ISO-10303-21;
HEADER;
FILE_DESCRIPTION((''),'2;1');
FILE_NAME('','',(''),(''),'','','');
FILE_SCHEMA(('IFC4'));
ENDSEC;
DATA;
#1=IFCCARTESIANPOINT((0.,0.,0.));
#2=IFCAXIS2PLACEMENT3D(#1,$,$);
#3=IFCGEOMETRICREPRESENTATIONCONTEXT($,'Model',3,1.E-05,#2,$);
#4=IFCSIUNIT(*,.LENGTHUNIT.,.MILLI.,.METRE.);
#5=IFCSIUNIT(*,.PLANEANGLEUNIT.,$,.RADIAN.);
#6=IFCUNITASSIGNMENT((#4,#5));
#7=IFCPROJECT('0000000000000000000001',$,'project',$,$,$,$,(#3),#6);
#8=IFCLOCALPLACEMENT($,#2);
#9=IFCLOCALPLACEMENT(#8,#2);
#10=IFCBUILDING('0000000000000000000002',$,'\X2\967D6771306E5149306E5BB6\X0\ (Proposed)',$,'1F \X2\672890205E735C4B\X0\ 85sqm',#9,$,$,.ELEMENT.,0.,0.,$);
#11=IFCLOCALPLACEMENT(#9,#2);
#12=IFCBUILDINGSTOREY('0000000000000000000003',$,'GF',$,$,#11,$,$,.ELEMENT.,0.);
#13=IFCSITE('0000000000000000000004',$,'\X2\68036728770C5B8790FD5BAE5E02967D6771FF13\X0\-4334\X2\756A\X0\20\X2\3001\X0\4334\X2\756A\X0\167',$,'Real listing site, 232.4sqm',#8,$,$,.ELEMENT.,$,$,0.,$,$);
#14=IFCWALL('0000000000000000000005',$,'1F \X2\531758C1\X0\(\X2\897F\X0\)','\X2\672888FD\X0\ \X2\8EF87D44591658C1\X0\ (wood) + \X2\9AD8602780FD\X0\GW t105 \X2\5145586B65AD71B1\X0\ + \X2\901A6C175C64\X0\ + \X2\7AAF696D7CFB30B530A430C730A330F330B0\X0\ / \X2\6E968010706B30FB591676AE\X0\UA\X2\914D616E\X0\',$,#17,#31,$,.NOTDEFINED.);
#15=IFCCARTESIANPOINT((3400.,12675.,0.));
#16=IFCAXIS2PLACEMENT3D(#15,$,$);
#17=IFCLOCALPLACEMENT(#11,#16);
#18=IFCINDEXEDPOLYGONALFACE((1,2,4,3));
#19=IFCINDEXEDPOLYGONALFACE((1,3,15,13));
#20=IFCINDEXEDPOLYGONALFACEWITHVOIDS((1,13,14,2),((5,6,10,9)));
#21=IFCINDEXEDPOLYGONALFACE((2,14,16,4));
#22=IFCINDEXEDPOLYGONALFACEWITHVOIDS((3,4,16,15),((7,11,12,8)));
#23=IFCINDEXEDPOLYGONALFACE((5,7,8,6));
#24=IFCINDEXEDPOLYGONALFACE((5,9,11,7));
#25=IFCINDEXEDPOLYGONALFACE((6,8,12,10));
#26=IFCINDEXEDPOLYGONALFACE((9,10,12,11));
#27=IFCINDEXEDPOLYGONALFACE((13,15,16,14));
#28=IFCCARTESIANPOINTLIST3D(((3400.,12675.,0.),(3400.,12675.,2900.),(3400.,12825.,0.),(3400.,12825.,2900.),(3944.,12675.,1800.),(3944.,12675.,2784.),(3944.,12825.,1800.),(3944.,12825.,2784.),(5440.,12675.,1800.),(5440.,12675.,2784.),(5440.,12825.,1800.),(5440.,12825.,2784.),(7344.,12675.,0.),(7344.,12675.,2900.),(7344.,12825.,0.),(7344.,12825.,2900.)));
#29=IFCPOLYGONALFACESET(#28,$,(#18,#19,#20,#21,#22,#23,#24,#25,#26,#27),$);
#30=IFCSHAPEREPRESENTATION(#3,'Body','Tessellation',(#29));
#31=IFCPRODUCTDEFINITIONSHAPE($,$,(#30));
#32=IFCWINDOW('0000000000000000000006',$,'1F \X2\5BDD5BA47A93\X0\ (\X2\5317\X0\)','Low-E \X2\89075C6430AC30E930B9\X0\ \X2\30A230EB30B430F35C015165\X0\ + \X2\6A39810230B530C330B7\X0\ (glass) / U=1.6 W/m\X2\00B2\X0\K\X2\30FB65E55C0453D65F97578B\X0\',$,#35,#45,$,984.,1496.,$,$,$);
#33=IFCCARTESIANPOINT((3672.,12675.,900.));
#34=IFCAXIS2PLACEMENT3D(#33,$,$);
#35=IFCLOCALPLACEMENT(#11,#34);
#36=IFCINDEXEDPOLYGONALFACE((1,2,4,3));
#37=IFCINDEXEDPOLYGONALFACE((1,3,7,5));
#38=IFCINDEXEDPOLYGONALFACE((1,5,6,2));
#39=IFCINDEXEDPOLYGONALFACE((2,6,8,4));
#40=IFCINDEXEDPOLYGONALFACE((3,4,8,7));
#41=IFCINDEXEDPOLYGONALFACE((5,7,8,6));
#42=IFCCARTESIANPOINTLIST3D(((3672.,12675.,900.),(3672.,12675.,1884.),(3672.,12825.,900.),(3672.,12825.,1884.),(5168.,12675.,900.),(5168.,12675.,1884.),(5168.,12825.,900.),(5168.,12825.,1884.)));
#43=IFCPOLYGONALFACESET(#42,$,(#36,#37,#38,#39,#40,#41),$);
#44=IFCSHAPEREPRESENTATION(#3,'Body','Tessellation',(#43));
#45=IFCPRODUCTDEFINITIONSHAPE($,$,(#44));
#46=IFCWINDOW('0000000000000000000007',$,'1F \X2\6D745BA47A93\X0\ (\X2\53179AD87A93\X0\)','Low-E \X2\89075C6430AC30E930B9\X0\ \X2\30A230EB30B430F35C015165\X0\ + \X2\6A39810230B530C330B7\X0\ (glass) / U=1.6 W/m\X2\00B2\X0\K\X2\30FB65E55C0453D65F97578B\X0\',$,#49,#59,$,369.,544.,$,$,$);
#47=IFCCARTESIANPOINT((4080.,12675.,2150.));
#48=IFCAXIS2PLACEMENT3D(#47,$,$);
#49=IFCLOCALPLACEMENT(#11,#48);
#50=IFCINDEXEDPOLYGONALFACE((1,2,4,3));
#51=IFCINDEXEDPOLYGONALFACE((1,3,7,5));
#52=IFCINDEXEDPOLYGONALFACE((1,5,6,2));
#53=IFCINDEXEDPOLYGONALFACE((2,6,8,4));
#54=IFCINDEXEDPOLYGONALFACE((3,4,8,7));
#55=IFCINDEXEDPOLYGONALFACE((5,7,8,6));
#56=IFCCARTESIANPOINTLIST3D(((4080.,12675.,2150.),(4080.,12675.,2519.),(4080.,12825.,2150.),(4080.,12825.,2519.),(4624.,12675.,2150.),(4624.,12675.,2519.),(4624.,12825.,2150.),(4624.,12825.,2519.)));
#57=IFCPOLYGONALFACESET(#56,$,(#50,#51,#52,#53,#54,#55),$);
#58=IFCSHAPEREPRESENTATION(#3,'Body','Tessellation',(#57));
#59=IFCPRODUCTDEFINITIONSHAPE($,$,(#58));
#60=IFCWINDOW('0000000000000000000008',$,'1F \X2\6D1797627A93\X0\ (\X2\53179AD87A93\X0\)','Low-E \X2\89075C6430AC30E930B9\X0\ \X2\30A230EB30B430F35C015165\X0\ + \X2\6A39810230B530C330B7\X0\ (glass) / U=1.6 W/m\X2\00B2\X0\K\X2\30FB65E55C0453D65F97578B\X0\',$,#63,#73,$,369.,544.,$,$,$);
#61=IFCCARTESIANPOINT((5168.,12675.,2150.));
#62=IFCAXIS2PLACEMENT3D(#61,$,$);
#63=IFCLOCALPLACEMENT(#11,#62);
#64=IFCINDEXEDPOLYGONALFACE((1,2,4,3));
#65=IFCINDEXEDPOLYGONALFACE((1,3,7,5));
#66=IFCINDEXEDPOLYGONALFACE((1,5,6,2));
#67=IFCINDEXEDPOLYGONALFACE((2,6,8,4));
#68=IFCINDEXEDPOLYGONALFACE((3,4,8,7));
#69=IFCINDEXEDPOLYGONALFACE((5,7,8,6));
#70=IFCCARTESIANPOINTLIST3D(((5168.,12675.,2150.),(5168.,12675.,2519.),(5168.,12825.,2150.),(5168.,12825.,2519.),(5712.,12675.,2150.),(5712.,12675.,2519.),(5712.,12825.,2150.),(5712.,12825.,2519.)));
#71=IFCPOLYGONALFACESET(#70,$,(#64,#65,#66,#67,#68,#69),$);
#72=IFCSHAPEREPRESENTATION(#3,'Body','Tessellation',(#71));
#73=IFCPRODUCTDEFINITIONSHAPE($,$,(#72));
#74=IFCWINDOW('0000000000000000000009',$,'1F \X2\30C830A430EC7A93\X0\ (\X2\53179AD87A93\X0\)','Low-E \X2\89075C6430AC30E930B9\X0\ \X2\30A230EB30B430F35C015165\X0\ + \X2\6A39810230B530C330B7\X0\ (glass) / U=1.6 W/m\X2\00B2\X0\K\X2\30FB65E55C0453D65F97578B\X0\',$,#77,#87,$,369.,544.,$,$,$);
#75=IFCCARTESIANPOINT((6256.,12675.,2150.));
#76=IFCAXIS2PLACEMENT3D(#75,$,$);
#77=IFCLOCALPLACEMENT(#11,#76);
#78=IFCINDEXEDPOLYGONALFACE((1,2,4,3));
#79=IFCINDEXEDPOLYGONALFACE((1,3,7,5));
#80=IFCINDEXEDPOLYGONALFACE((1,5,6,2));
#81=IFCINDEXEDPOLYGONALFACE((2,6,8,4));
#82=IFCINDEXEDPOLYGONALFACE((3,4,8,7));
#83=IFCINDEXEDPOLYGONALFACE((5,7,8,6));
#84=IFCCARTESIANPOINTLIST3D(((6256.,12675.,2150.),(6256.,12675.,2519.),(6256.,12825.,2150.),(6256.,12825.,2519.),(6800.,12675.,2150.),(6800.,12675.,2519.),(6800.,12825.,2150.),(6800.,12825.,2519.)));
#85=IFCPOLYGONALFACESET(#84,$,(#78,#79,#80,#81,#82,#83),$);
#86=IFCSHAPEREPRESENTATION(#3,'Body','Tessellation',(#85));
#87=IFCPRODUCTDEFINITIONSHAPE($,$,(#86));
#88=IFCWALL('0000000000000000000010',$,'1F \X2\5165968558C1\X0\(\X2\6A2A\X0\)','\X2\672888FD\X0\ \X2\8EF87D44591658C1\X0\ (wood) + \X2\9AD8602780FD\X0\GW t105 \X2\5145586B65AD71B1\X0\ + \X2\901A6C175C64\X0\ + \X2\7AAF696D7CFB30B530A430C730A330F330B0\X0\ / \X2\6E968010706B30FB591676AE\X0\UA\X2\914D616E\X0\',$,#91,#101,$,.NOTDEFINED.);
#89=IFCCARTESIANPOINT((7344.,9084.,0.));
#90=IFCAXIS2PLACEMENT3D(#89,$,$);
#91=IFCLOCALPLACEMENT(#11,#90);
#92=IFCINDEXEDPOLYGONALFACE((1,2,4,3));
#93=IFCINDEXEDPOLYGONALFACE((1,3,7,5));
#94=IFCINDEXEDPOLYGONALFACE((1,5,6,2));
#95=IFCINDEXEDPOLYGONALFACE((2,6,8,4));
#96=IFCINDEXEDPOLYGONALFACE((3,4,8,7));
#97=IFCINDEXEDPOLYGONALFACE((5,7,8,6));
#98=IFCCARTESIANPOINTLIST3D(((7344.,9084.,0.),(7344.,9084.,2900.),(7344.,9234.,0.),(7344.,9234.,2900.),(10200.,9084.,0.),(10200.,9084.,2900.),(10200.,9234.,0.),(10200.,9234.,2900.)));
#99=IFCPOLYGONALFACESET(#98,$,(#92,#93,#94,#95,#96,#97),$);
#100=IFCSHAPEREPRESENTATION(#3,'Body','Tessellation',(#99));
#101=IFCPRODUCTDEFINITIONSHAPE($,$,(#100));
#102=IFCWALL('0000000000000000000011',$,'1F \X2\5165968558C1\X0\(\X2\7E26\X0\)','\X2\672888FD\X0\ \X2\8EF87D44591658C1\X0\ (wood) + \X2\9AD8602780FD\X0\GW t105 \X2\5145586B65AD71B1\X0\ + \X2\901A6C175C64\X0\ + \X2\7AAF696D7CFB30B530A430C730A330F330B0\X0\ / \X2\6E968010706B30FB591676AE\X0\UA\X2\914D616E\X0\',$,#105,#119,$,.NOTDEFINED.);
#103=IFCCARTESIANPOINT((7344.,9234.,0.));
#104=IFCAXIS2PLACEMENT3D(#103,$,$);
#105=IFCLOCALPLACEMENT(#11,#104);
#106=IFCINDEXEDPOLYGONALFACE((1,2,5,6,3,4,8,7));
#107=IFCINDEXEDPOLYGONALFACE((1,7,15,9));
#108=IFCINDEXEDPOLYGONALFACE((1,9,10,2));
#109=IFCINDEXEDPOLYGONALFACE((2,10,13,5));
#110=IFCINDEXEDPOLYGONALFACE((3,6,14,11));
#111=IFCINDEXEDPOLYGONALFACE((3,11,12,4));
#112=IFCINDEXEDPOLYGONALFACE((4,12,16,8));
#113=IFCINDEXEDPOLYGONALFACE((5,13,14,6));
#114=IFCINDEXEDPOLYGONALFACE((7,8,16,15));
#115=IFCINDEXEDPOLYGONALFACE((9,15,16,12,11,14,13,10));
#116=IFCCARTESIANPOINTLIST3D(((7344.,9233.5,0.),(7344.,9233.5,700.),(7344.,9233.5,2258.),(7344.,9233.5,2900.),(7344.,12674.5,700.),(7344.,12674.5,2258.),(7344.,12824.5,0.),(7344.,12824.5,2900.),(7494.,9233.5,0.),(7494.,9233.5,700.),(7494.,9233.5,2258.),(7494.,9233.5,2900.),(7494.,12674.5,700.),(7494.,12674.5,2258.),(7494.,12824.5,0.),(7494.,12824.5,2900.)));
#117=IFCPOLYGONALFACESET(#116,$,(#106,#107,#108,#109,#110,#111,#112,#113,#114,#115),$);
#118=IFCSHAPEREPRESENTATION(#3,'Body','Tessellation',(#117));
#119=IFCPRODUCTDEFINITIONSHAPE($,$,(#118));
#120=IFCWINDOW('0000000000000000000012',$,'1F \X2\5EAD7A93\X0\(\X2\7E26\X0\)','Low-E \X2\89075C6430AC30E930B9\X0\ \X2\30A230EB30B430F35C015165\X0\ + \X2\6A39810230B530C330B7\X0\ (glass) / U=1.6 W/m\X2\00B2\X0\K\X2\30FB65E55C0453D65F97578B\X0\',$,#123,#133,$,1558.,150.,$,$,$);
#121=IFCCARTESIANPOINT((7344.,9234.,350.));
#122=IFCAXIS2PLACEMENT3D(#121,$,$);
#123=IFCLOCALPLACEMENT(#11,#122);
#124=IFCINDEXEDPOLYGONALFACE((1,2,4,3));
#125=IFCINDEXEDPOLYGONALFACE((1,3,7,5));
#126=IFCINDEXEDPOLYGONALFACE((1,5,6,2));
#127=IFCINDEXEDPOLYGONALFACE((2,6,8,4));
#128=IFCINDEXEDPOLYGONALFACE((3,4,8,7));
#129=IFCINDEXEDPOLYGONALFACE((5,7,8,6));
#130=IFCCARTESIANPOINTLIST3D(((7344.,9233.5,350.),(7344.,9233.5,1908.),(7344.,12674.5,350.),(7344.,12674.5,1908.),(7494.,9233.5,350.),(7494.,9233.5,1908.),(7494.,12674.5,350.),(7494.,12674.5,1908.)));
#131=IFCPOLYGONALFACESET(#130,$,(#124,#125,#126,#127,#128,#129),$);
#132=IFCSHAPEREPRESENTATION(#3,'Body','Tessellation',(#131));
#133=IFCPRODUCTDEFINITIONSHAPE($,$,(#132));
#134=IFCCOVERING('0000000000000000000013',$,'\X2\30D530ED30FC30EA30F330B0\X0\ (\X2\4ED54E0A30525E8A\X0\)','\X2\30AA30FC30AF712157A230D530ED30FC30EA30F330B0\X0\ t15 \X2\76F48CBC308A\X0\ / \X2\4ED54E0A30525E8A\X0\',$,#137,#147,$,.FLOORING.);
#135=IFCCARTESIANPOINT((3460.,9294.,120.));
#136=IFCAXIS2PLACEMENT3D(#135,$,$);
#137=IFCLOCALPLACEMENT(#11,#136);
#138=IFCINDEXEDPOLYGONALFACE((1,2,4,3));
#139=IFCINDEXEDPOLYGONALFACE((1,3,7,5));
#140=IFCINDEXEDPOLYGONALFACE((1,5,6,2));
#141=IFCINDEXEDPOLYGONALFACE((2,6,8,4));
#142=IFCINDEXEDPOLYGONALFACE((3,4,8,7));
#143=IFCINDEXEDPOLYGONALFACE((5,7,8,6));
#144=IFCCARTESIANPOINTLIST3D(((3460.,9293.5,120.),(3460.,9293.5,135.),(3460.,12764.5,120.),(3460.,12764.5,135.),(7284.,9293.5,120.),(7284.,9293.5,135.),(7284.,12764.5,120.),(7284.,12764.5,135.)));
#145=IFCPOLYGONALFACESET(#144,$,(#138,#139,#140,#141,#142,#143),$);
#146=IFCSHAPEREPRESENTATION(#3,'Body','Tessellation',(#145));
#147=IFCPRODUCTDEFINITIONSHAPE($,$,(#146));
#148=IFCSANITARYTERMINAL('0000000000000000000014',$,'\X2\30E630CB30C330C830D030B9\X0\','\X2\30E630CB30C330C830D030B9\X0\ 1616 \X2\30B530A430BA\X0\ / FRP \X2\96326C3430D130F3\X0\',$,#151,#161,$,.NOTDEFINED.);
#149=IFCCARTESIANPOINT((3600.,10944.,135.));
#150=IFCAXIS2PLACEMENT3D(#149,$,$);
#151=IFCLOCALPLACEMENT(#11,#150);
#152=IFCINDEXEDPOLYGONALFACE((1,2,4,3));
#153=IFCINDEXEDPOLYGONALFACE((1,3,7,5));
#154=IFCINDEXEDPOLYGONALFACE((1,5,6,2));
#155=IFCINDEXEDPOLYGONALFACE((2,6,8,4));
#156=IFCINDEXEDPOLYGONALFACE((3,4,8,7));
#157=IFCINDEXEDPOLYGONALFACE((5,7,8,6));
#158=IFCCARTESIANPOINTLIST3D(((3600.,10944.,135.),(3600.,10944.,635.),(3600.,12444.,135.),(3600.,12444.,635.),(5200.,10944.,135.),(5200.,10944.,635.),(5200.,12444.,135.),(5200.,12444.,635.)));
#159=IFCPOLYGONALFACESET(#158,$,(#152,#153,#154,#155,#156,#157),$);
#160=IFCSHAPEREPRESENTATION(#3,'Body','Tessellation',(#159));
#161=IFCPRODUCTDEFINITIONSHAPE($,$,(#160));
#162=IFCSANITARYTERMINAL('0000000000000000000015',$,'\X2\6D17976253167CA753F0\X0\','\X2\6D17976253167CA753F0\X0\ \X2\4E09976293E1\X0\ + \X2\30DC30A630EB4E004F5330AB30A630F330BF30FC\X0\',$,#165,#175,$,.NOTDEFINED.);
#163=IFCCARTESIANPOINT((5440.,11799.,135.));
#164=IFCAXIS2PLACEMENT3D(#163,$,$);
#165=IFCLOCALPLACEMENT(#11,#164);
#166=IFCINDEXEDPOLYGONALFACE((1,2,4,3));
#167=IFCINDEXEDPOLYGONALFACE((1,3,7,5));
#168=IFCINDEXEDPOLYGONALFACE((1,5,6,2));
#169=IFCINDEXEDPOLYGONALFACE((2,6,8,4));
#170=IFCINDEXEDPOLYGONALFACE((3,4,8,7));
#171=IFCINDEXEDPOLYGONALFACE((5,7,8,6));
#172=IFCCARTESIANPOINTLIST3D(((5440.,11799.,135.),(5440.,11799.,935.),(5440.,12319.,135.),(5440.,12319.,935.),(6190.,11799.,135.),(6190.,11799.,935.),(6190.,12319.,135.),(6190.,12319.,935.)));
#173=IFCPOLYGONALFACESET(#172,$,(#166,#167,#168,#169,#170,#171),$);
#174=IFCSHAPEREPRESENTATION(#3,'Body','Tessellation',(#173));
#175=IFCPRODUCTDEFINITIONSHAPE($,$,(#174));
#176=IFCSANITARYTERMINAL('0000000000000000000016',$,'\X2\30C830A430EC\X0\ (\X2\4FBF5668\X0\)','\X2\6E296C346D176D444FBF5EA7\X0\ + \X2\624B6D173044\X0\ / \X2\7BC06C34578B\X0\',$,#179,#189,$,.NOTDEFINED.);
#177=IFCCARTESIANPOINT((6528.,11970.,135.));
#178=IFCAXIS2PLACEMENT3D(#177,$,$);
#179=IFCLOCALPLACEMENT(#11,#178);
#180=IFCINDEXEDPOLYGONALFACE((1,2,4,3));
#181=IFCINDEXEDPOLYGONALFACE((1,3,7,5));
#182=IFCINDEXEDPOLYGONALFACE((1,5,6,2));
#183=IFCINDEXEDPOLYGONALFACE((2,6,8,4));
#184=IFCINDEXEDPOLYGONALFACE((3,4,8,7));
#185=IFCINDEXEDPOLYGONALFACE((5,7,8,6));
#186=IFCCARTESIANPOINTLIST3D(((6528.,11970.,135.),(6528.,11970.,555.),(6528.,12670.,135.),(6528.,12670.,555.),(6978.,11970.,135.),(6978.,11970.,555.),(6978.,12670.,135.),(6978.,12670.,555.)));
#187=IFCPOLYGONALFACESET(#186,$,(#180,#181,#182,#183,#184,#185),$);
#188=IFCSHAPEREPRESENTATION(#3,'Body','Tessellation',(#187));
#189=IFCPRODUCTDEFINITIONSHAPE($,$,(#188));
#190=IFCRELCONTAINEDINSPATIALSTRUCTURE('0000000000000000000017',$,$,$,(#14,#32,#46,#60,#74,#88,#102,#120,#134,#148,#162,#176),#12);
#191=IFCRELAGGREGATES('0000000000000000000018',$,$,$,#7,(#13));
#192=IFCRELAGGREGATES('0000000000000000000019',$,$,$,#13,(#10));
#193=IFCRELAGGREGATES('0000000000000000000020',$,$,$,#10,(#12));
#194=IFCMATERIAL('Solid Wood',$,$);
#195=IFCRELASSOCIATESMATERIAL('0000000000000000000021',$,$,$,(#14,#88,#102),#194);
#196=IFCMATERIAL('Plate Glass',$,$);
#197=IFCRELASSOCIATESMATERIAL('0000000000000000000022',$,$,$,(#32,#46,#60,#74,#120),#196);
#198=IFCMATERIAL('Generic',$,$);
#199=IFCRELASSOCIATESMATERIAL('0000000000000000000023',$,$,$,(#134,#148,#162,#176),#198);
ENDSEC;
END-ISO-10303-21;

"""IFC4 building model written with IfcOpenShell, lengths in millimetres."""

from ifc_helpers import new_model, si_unit, frame, frame_2d, origin, place, context, project, spatial, rectangle, extrude, material, element, fill, save


model = new_model("IFC4")

# Units and contexts
model_context = context("Model", 3, precision=1e-05, world=origin())
ifc_project = project(units=[si_unit("LENGTHUNIT", "METRE", prefix="MILLI"), si_unit("PLANEANGLEUNIT", "RADIAN")], contexts=[model_context])

# Site, building, storey
site_placement = place(None, origin())
site = spatial("IfcSite", under=ifc_project, at=site_placement, Name="栃木県宇都宮市陽東３-4334番20、4334番167", ObjectType="Real listing site, 232.4sqm", CompositionType="ELEMENT", RefElevation=0.0)
building_placement = place(site_placement, origin())
building = spatial("IfcBuilding", under=site, at=building_placement, Name="陽東の光の家 (Proposed)", ObjectType="1F 木造平屋 85sqm", CompositionType="ELEMENT", ElevationOfRefHeight=0.0, ElevationOfTerrain=0.0)
storey_placement = place(building_placement, origin())
storey = spatial("IfcBuildingStorey", under=building, at=storey_placement, Name="GF", CompositionType="ELEMENT", Elevation=0.0)

# Shared definitions
ifc_material_1 = material(Name="Solid Wood")

# Wall, openings, windows
wall_1_placement = place(storey_placement, frame((3400.0, 12675.0, 0.0)))
wall_1 = element("IfcWall", 1, at=wall_1_placement, inside=storey, material=ifc_material_1, Name="1F 北壁(西)", Description="木製 軸組外壁 (wood) + 高性能GW t105 充填断熱 + 通気層 + 窯業系サイディング / 準耐火・外皮UA配慮", PredefinedType="NOTDEFINED", context=model_context, shape_type="SweptSolid", body=[
    extrude(rectangle(XDim=3944.0, YDim=150.0, at=frame_2d((1972.0, 75.0))), frame((3400.0, 12675.0, 0.0)), (0.0, 0.0, 1.0), 2900.0),
])
opening_1_placement = place(storey_placement, frame((3672.0, 12675.0, 900.0)))
opening_1 = element("IfcOpeningElement", 2, at=opening_1_placement, cuts=wall_1, PredefinedType="NOTDEFINED", context=model_context, shape_type="SweptSolid", body=[
    extrude(rectangle(XDim=1496.0, YDim=150.0, at=frame_2d((748.0, 75.0))), frame((3672.0, 12675.0, 900.0)), (0.0, 0.0, 1.0), 984.0),
])
opening_2_placement = place(storey_placement, frame((4080.0, 12675.0, 2150.0)))
opening_2 = element("IfcOpeningElement", 3, at=opening_2_placement, cuts=wall_1, PredefinedType="NOTDEFINED", context=model_context, shape_type="SweptSolid", body=[
    extrude(rectangle(XDim=544.0, YDim=150.0, at=frame_2d((272.0, 75.0))), frame((4080.0, 12675.0, 2150.0)), (0.0, 0.0, 1.0), 369.0),
])
opening_3_placement = place(storey_placement, frame((5168.0, 12675.0, 2150.0)))
opening_3 = element("IfcOpeningElement", 4, at=opening_3_placement, cuts=wall_1, PredefinedType="NOTDEFINED", context=model_context, shape_type="SweptSolid", body=[
    extrude(rectangle(XDim=544.0, YDim=150.0, at=frame_2d((272.0, 75.0))), frame((5168.0, 12675.0, 2150.0)), (0.0, 0.0, 1.0), 369.0),
])
opening_4_placement = place(storey_placement, frame((6256.0, 12675.0, 2150.0)))
opening_4 = element("IfcOpeningElement", 5, at=opening_4_placement, cuts=wall_1, PredefinedType="NOTDEFINED", context=model_context, shape_type="SweptSolid", body=[
    extrude(rectangle(XDim=544.0, YDim=150.0, at=frame_2d((272.0, 75.0))), frame((6256.0, 12675.0, 2150.0)), (0.0, 0.0, 1.0), 369.0),
])
ifc_material_2 = material(Name="Plate Glass")
window_1_placement = place(storey_placement, frame((3672.0, 12675.0, 900.0)))
window_1 = element("IfcWindow", 6, at=window_1_placement, inside=storey, material=ifc_material_2, Name="1F 寝室窓 (北)", Description="Low-E 複層ガラス アルゴン封入 + 樹脂サッシ (glass) / U=1.6 W/m²K・日射取得型", OverallHeight=984.0, OverallWidth=1496.0, context=model_context, shape_type="SweptSolid", body=[
    extrude(rectangle(XDim=1496.0, YDim=150.0, at=frame_2d((748.0, 75.0))), frame((3672.0, 12675.0, 900.0)), (0.0, 0.0, 1.0), 984.0),
])
fill(opening_1, window_1)
window_2_placement = place(storey_placement, frame((4080.0, 12675.0, 2150.0)))
window_2 = element("IfcWindow", 7, at=window_2_placement, inside=storey, material=ifc_material_2, Name="1F 浴室窓 (北高窓)", Description="Low-E 複層ガラス アルゴン封入 + 樹脂サッシ (glass) / U=1.6 W/m²K・日射取得型", OverallHeight=369.0, OverallWidth=544.0, context=model_context, shape_type="SweptSolid", body=[
    extrude(rectangle(XDim=544.0, YDim=150.0, at=frame_2d((272.0, 75.0))), frame((4080.0, 12675.0, 2150.0)), (0.0, 0.0, 1.0), 369.0),
])
fill(opening_2, window_2)
window_3_placement = place(storey_placement, frame((5168.0, 12675.0, 2150.0)))
window_3 = element("IfcWindow", 8, at=window_3_placement, inside=storey, material=ifc_material_2, Name="1F 洗面窓 (北高窓)", Description="Low-E 複層ガラス アルゴン封入 + 樹脂サッシ (glass) / U=1.6 W/m²K・日射取得型", OverallHeight=369.0, OverallWidth=544.0, context=model_context, shape_type="SweptSolid", body=[
    extrude(rectangle(XDim=544.0, YDim=150.0, at=frame_2d((272.0, 75.0))), frame((5168.0, 12675.0, 2150.0)), (0.0, 0.0, 1.0), 369.0),
])
fill(opening_3, window_3)
window_4_placement = place(storey_placement, frame((6256.0, 12675.0, 2150.0)))
window_4 = element("IfcWindow", 9, at=window_4_placement, inside=storey, material=ifc_material_2, Name="1F トイレ窓 (北高窓)", Description="Low-E 複層ガラス アルゴン封入 + 樹脂サッシ (glass) / U=1.6 W/m²K・日射取得型", OverallHeight=369.0, OverallWidth=544.0, context=model_context, shape_type="SweptSolid", body=[
    extrude(rectangle(XDim=544.0, YDim=150.0, at=frame_2d((272.0, 75.0))), frame((6256.0, 12675.0, 2150.0)), (0.0, 0.0, 1.0), 369.0),
])
fill(opening_4, window_4)

# Wall
wall_2_placement = place(storey_placement, frame((7344.0, 9084.0, 0.0)))
element("IfcWall", 10, at=wall_2_placement, inside=storey, material=ifc_material_1, Name="1F 入隅壁(横)", Description="木製 軸組外壁 (wood) + 高性能GW t105 充填断熱 + 通気層 + 窯業系サイディング / 準耐火・外皮UA配慮", PredefinedType="NOTDEFINED", context=model_context, shape_type="SweptSolid", body=[
    extrude(rectangle(XDim=2856.0, YDim=150.0, at=frame_2d((1428.0, 75.0))), frame((7344.0, 9084.0, 0.0)), (0.0, 0.0, 1.0), 2900.0),
])

# Wall, opening, window
wall_3_placement = place(storey_placement, frame((7344.0, 9234.0, 0.0)))
wall_3 = element("IfcWall", 11, at=wall_3_placement, inside=storey, material=ifc_material_1, Name="1F 入隅壁(縦)", Description="木製 軸組外壁 (wood) + 高性能GW t105 充填断熱 + 通気層 + 窯業系サイディング / 準耐火・外皮UA配慮", PredefinedType="NOTDEFINED", context=model_context, shape_type="SweptSolid", body=[
    extrude(rectangle(XDim=150.0, YDim=3591.0, at=frame_2d((75.0, 1795.0))), frame((7344.0, 9234.0, 0.0)), (0.0, 0.0, 1.0), 2900.0),
])
opening_5_placement = place(storey_placement, frame((7344.0, 9234.0, 350.0)))
opening_5 = element("IfcOpeningElement", 12, at=opening_5_placement, cuts=wall_3, PredefinedType="NOTDEFINED", context=model_context, shape_type="SweptSolid", body=[
    extrude(rectangle(XDim=150.0, YDim=3441.0, at=frame_2d((75.0, 1720.0))), frame((7344.0, 9234.0, 350.0)), (0.0, 0.0, 1.0), 1558.0),
])
window_5_placement = place(storey_placement, frame((7344.0, 9234.0, 350.0)))
window_5 = element("IfcWindow", 13, at=window_5_placement, inside=storey, material=ifc_material_2, Name="1F 庭窓(縦)", Description="Low-E 複層ガラス アルゴン封入 + 樹脂サッシ (glass) / U=1.6 W/m²K・日射取得型", OverallHeight=1558.0, OverallWidth=150.0, context=model_context, shape_type="SweptSolid", body=[
    extrude(rectangle(XDim=150.0, YDim=3441.0, at=frame_2d((75.0, 1720.0))), frame((7344.0, 9234.0, 350.0)), (0.0, 0.0, 1.0), 1558.0),
])
fill(opening_5, window_5)

# Covering
ifc_material_3 = material(Name="Generic")
covering_placement = place(storey_placement, frame((3460.0, 9294.0, 120.0)))
element("IfcCovering", 14, at=covering_placement, inside=storey, material=ifc_material_3, Name="フローリング (仕上げ床)", Description="オーク無垢フローリング t15 直貼り / 仕上げ床", PredefinedType="FLOORING", context=model_context, shape_type="SweptSolid", body=[
    extrude(rectangle(XDim=3824.0, YDim=3471.0, at=frame_2d((1912.0, 1735.0))), frame((3460.0, 9294.0, 120.0)), (0.0, 0.0, 1.0), 15.0),
])

# Sanitary terminals
sanitary_terminal_1_placement = place(storey_placement, frame((3600.0, 10944.0, 135.0)))
element("IfcSanitaryTerminal", 15, at=sanitary_terminal_1_placement, inside=storey, material=ifc_material_3, Name="ユニットバス", Description="ユニットバス 1616 サイズ / FRP 防水パン", PredefinedType="NOTDEFINED", context=model_context, shape_type="SweptSolid", body=[
    extrude(rectangle(XDim=1600.0, YDim=1500.0, at=frame_2d((800.0, 750.0))), frame((3600.0, 10944.0, 135.0)), (0.0, 0.0, 1.0), 500.0),
])
sanitary_terminal_2_placement = place(storey_placement, frame((5440.0, 11799.0, 135.0)))
element("IfcSanitaryTerminal", 16, at=sanitary_terminal_2_placement, inside=storey, material=ifc_material_3, Name="洗面化粧台", Description="洗面化粧台 三面鏡 + ボウル一体カウンター", PredefinedType="NOTDEFINED", context=model_context, shape_type="SweptSolid", body=[
    extrude(rectangle(XDim=750.0, YDim=520.0, at=frame_2d((375.0, 260.0))), frame((5440.0, 11799.0, 135.0)), (0.0, 0.0, 1.0), 800.0),
])
sanitary_terminal_3_placement = place(storey_placement, frame((6528.0, 11970.0, 135.0)))
element("IfcSanitaryTerminal", 17, at=sanitary_terminal_3_placement, inside=storey, material=ifc_material_3, Name="トイレ (便器)", Description="温水洗浄便座 + 手洗い / 節水型", PredefinedType="NOTDEFINED", context=model_context, shape_type="SweptSolid", body=[
    extrude(rectangle(XDim=450.0, YDim=700.0, at=frame_2d((225.0, 350.0))), frame((6528.0, 11970.0, 135.0)), (0.0, 0.0, 1.0), 420.0),
])

save(model, "model.ifc")
